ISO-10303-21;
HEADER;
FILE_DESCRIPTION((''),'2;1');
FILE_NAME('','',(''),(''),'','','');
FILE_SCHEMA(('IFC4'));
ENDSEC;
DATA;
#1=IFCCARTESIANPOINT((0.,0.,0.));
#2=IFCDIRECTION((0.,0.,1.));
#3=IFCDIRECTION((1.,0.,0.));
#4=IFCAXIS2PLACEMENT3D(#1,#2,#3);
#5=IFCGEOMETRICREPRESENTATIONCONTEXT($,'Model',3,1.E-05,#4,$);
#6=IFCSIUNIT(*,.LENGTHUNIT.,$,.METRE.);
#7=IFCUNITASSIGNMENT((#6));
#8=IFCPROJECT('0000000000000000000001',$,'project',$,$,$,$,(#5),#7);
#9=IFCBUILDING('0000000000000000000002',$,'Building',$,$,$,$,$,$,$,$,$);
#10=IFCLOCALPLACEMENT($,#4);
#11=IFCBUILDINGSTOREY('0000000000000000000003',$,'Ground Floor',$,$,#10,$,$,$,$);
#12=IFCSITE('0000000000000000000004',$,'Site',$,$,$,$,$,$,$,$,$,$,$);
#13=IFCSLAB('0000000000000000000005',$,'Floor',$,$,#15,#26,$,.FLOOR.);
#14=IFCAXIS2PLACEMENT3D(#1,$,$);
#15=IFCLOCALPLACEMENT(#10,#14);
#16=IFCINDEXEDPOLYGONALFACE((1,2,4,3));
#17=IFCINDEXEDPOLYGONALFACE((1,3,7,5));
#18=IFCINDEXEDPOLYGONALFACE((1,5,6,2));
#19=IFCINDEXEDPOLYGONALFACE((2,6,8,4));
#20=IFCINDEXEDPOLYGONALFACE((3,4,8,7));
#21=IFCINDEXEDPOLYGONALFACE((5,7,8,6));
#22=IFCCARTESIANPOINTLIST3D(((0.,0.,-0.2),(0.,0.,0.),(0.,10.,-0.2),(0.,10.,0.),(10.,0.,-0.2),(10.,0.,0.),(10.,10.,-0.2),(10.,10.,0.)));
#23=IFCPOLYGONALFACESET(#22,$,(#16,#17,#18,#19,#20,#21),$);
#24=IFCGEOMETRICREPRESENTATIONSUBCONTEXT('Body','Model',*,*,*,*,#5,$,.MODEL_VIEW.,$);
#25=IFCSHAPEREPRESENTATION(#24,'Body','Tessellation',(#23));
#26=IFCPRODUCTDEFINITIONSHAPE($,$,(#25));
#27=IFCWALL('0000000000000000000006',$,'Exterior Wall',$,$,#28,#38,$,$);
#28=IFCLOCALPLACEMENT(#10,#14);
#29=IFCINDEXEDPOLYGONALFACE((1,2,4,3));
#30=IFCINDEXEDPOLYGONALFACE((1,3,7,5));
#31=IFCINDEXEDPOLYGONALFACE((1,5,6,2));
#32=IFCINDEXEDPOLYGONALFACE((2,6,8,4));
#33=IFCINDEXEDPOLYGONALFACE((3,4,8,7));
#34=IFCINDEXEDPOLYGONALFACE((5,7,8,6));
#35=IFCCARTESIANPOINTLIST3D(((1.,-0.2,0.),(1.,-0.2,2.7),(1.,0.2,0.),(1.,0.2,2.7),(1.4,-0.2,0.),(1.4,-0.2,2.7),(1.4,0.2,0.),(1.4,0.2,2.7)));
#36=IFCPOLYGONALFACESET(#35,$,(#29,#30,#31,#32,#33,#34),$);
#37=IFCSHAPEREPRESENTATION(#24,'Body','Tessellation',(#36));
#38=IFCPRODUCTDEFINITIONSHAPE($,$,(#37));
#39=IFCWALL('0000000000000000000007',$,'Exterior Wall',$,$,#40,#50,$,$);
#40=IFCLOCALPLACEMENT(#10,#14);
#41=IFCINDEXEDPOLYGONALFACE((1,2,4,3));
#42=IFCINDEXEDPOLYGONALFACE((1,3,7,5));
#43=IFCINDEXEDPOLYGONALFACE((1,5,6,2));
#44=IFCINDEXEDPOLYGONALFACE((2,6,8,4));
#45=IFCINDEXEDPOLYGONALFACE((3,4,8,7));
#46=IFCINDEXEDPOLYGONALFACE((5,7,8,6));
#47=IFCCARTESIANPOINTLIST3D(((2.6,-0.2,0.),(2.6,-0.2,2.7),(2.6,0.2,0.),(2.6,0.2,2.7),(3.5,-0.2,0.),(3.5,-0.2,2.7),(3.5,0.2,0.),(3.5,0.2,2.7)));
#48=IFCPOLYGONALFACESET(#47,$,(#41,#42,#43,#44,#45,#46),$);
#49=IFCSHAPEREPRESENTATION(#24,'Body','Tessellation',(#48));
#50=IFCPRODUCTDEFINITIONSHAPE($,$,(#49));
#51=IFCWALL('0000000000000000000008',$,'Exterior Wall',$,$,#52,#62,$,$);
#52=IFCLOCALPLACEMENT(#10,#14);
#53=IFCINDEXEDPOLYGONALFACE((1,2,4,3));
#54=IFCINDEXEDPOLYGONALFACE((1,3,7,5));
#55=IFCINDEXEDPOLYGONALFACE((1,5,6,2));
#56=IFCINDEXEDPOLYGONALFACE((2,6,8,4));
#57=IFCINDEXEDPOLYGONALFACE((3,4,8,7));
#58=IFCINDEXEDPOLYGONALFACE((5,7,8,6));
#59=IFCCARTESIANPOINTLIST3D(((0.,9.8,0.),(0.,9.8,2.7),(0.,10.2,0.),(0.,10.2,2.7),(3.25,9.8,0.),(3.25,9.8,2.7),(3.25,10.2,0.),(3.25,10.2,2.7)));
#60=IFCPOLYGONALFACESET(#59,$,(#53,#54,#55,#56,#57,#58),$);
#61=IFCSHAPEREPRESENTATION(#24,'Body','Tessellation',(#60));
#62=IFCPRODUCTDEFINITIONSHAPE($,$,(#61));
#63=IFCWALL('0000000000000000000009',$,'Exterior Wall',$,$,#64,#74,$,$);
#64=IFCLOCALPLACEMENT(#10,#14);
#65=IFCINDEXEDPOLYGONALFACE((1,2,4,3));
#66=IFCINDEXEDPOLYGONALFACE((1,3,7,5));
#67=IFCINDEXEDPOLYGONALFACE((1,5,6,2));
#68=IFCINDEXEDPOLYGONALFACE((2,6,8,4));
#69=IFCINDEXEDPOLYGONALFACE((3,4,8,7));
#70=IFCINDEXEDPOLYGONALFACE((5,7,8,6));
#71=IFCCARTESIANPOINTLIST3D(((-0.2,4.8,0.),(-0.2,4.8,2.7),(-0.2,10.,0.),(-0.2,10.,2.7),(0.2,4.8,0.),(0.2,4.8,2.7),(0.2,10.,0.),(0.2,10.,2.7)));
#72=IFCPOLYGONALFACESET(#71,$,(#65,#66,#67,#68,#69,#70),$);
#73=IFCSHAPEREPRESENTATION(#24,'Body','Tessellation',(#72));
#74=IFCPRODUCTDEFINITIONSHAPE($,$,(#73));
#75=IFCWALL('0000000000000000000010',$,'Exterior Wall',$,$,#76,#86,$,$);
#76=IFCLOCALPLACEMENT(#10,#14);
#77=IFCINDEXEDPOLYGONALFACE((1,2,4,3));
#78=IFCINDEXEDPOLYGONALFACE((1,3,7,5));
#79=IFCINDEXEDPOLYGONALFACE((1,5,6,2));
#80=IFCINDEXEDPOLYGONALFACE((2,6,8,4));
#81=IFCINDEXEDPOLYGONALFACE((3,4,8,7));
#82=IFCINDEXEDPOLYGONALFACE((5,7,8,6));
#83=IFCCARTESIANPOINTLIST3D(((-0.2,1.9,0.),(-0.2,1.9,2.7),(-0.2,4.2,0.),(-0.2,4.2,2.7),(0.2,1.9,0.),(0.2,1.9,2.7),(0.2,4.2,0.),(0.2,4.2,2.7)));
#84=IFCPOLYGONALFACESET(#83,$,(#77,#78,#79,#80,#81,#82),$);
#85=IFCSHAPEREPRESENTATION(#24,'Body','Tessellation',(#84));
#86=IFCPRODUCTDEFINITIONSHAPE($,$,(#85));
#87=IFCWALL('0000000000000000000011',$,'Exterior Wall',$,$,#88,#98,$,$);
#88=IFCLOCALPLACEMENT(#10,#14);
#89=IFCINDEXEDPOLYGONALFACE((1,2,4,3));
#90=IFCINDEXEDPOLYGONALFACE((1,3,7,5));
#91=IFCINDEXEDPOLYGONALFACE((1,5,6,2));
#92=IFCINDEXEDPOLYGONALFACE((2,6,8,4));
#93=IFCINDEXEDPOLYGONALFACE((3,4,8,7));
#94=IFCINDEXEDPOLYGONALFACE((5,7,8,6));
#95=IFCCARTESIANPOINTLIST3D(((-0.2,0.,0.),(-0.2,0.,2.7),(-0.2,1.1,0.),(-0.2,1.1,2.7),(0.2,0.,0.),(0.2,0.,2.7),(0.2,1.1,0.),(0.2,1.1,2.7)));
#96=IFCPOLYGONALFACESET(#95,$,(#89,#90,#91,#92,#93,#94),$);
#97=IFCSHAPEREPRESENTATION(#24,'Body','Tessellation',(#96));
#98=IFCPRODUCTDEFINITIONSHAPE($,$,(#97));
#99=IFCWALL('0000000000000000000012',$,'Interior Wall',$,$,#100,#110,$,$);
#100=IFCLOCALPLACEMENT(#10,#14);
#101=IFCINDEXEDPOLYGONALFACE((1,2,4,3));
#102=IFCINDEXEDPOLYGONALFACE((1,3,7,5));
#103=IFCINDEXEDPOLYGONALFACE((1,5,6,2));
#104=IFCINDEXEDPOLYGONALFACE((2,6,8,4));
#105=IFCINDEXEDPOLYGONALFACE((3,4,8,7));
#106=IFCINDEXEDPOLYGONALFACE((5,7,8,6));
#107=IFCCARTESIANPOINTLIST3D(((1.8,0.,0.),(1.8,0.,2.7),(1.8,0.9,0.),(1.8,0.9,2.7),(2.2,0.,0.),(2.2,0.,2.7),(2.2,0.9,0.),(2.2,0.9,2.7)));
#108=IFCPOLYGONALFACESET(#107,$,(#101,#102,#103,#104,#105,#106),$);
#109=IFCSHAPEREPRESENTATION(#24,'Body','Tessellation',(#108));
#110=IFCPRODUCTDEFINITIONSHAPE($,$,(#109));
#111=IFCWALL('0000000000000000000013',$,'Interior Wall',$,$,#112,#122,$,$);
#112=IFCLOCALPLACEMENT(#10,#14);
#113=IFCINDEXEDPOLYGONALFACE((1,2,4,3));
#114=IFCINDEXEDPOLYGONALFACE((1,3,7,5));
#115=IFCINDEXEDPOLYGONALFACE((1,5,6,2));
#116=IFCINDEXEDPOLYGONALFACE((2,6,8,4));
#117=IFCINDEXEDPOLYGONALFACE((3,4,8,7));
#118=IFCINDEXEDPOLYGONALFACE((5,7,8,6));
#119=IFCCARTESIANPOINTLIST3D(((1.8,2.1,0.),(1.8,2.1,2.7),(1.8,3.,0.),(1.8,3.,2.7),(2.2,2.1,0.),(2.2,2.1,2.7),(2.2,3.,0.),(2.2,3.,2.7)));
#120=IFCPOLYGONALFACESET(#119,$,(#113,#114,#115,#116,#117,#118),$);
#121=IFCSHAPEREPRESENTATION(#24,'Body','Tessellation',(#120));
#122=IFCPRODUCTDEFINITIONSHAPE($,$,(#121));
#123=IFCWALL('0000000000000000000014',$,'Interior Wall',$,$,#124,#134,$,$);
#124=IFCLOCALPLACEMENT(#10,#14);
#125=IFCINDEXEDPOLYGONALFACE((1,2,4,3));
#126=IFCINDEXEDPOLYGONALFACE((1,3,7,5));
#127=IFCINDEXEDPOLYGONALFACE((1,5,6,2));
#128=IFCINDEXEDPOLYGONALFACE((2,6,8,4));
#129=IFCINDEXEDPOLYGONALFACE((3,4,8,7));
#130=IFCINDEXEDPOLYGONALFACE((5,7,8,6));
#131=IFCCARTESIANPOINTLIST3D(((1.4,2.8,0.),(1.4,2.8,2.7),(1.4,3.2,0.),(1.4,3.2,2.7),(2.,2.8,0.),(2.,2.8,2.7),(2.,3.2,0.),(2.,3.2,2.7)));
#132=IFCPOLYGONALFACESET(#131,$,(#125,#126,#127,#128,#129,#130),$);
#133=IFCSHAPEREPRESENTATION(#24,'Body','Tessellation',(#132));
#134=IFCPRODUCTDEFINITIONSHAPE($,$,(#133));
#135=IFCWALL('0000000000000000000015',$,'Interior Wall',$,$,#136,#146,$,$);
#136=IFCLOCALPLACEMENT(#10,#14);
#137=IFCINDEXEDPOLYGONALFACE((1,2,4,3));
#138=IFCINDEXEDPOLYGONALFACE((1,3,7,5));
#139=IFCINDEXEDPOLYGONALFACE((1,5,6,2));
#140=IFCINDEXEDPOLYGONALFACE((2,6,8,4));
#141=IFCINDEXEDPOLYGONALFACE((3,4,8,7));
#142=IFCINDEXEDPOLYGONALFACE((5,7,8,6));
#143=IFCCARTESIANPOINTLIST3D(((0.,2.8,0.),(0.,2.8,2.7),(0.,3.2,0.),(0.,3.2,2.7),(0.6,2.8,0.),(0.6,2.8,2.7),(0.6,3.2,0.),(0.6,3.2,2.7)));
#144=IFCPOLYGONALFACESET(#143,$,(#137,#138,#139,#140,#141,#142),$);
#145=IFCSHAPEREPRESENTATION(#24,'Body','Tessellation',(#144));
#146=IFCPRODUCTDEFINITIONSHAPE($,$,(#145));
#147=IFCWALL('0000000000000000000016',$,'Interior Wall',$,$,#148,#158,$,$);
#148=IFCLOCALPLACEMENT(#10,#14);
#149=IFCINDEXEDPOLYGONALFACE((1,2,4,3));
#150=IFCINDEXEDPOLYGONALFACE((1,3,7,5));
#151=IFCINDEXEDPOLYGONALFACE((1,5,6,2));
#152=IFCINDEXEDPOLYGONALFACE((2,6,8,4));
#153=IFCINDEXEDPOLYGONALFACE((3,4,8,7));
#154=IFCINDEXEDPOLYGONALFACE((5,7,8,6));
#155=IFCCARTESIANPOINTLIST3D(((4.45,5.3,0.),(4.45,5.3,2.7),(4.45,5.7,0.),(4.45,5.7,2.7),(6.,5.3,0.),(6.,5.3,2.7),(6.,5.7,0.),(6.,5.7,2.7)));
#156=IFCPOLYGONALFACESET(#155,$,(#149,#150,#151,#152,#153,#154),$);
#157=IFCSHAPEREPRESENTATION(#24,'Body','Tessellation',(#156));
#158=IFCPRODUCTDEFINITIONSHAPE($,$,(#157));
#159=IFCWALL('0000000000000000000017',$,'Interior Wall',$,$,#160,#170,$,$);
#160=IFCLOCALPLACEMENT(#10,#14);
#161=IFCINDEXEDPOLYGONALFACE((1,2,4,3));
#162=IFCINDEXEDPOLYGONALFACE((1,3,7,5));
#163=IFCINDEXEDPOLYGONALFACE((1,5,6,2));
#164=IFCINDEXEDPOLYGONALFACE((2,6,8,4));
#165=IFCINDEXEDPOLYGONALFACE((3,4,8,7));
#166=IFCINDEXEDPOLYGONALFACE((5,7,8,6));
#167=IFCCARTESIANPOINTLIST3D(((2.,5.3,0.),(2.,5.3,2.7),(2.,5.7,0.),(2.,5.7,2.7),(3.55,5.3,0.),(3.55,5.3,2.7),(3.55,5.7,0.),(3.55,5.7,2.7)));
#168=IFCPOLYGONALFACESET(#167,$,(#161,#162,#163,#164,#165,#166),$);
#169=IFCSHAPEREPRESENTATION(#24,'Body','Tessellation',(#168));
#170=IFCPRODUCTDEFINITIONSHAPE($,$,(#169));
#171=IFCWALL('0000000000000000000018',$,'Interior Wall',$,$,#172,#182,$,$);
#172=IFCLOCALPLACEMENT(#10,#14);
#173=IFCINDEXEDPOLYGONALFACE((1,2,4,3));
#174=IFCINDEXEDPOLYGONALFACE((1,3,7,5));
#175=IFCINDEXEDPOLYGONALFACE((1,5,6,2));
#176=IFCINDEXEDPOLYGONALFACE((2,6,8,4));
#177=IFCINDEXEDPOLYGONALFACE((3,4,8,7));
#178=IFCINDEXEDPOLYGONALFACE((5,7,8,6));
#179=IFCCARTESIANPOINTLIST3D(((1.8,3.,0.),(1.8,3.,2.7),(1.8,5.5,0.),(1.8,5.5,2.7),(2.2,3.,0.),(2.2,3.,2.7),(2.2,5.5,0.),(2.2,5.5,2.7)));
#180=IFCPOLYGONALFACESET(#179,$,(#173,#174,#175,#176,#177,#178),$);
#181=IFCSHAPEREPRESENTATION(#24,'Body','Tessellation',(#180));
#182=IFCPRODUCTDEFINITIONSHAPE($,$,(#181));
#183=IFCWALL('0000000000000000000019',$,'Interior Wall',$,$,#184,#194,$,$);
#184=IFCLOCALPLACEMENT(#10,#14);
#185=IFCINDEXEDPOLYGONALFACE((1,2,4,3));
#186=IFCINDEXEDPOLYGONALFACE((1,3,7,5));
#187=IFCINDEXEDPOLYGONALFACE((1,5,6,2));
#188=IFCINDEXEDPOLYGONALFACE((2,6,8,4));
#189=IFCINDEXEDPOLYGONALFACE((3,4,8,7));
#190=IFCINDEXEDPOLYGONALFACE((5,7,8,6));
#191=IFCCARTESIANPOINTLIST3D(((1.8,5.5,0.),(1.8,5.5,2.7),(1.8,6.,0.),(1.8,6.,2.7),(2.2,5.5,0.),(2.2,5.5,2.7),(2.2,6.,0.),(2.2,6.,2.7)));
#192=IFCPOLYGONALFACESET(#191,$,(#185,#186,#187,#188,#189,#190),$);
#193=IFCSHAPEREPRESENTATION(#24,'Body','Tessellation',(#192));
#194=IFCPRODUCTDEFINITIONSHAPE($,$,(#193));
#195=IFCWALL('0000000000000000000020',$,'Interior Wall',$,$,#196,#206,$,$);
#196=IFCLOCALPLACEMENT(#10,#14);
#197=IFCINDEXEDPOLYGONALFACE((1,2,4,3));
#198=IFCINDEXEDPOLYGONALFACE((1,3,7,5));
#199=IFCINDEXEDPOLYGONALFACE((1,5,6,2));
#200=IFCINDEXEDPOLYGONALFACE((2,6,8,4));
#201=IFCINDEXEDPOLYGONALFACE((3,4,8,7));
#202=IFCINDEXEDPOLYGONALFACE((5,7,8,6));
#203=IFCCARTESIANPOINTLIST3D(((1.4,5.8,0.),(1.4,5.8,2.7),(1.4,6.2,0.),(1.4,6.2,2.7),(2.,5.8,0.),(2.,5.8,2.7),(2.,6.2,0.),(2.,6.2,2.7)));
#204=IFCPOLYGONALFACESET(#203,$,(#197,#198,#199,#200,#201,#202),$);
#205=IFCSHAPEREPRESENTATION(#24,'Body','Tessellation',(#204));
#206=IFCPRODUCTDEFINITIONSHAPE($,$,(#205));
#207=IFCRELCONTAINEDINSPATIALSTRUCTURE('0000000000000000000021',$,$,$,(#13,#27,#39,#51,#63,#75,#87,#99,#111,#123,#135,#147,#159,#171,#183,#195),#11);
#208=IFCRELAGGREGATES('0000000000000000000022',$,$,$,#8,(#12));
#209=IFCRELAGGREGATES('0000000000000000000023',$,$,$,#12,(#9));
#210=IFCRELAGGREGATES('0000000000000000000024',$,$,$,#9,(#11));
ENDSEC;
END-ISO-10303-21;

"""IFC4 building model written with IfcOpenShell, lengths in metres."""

from ifc_helpers import new_model, si_unit, frame, origin_with_axes, place, context, subcontext, project, spatial, indexed_curve, outline, extrude, element, save


model = new_model("IFC4")

# Units and contexts
model_context = context("Model", 3, precision=1e-05, world=origin_with_axes())
body_context = subcontext(model_context, "Body", "Model", "MODEL_VIEW")
ifc_project = project(units=[si_unit("LENGTHUNIT", "METRE")], contexts=[model_context])

# Site, building, storey
site = spatial("IfcSite", under=ifc_project, Name="Site")
building = spatial("IfcBuilding", under=site, Name="Building")
storey_placement = place(None, origin_with_axes())
storey = spatial("IfcBuildingStorey", under=building, at=storey_placement, Name="Ground Floor")

# Slab
slab_placement = place(storey_placement, frame((0.0, 0.0, -0.2), z_axis=(0.0, 0.0, 1.0), x_axis=(1.0, 0.0, 0.0)))
element("IfcSlab", 1, at=slab_placement, inside=storey, Name="Floor", PredefinedType="FLOOR", context=body_context, shape_type="SweptSolid", body=[
    extrude(outline(indexed_curve([(0.0, 0.0), (10.0, 0.0), (10.0, 10.0), (0.0, 10.0)])), None, (0.0, 0.0, 1.0), 0.2),
])

# Walls
wall_1_placement = place(storey_placement, frame((1.0, 0.0, 0.0), z_axis=(0.0, 0.0, 1.0), x_axis=(1.0, 0.0, 0.0)))
element("IfcWall", 2, at=wall_1_placement, inside=storey, Name="Exterior Wall", context=body_context, shape_type="SweptSolid", body=[
    extrude(outline(indexed_curve([(0.0, 0.0), (0.0, 0.4), (0.4, 0.4), (0.4, 0.0), (0.0, 0.0)], self_intersect=False)), frame((0.0, -0.2, 0.0), z_axis=(0.0, 0.0, 1.0), x_axis=(1.0, 0.0, 0.0)), (0.0, 0.0, 1.0), 2.7),
])
wall_2_placement = place(storey_placement, frame((2.6, 0.0, 0.0), z_axis=(0.0, 0.0, 1.0), x_axis=(1.0, 0.0, 0.0)))
element("IfcWall", 3, at=wall_2_placement, inside=storey, Name="Exterior Wall", context=body_context, shape_type="SweptSolid", body=[
    extrude(outline(indexed_curve([(0.0, 0.0), (0.0, 0.4), (0.9, 0.4), (0.9, 0.0), (0.0, 0.0)], self_intersect=False)), frame((0.0, -0.2, 0.0), z_axis=(0.0, 0.0, 1.0), x_axis=(1.0, 0.0, 0.0)), (0.0, 0.0, 1.0), 2.7),
])
wall_3_placement = place(storey_placement, frame((3.25, 10.0, 0.0), z_axis=(0.0, 0.0, 1.0), x_axis=(-1.0, 0.0, 0.0)))
element("IfcWall", 4, at=wall_3_placement, inside=storey, Name="Exterior Wall", context=body_context, shape_type="SweptSolid", body=[
    extrude(outline(indexed_curve([(0.0, 0.0), (0.0, 0.4), (3.25, 0.4), (3.25, 0.0), (0.0, 0.0)], self_intersect=False)), frame((0.0, -0.2, 0.0), z_axis=(0.0, 0.0, 1.0), x_axis=(1.0, 0.0, 0.0)), (0.0, 0.0, 1.0), 2.7),
])
wall_4_placement = place(storey_placement, frame((0.0, 10.0, 0.0), z_axis=(0.0, 0.0, 1.0), x_axis=(0.0, -1.0, 0.0)))
element("IfcWall", 5, at=wall_4_placement, inside=storey, Name="Exterior Wall", context=body_context, shape_type="SweptSolid", body=[
    extrude(outline(indexed_curve([(0.0, 0.0), (0.0, 0.4), (5.2, 0.4), (5.2, 0.0), (0.0, 0.0)], self_intersect=False)), frame((0.0, -0.2, 0.0), z_axis=(0.0, 0.0, 1.0), x_axis=(1.0, 0.0, 0.0)), (0.0, 0.0, 1.0), 2.7),
])
wall_5_placement = place(storey_placement, frame((0.0, 4.2, 0.0), z_axis=(0.0, 0.0, 1.0), x_axis=(0.0, -1.0, 0.0)))
element("IfcWall", 6, at=wall_5_placement, inside=storey, Name="Exterior Wall", context=body_context, shape_type="SweptSolid", body=[
    extrude(outline(indexed_curve([(0.0, 0.0), (0.0, 0.4), (2.3, 0.4), (2.3, 0.0), (0.0, 0.0)], self_intersect=False)), frame((0.0, -0.2, 0.0), z_axis=(0.0, 0.0, 1.0), x_axis=(1.0, 0.0, 0.0)), (0.0, 0.0, 1.0), 2.7),
])
wall_6_placement = place(storey_placement, frame((0.0, 1.1, 0.0), z_axis=(0.0, 0.0, 1.0), x_axis=(0.0, -1.0, 0.0)))
element("IfcWall", 7, at=wall_6_placement, inside=storey, Name="Exterior Wall", context=body_context, shape_type="SweptSolid", body=[
    extrude(outline(indexed_curve([(0.0, 0.0), (0.0, 0.4), (1.1, 0.4), (1.1, 0.0), (0.0, 0.0)], self_intersect=False)), frame((0.0, -0.2, 0.0), z_axis=(0.0, 0.0, 1.0), x_axis=(1.0, 0.0, 0.0)), (0.0, 0.0, 1.0), 2.7),
])
wall_7_placement = place(storey_placement, frame((2.0, 0.0, 0.0), z_axis=(0.0, 0.0, 1.0), x_axis=(0.0, 1.0, 0.0)))
element("IfcWall", 8, at=wall_7_placement, inside=storey, Name="Interior Wall", context=body_context, shape_type="SweptSolid", body=[
    extrude(outline(indexed_curve([(0.0, 0.0), (0.0, 0.4), (0.9, 0.4), (0.9, 0.0), (0.0, 0.0)], self_intersect=False)), frame((0.0, -0.2, 0.0), z_axis=(0.0, 0.0, 1.0), x_axis=(1.0, 0.0, 0.0)), (0.0, 0.0, 1.0), 2.7),
])
wall_8_placement = place(storey_placement, frame((2.0, 2.1, 0.0), z_axis=(0.0, 0.0, 1.0), x_axis=(0.0, 1.0, 0.0)))
element("IfcWall", 9, at=wall_8_placement, inside=storey, Name="Interior Wall", context=body_context, shape_type="SweptSolid", body=[
    extrude(outline(indexed_curve([(0.0, 0.0), (0.0, 0.4), (0.9, 0.4), (0.9, 0.0), (0.0, 0.0)], self_intersect=False)), frame((0.0, -0.2, 0.0), z_axis=(0.0, 0.0, 1.0), x_axis=(1.0, 0.0, 0.0)), (0.0, 0.0, 1.0), 2.7),
])
for number, where, z_axis, x_axis, name in (
    (10, (2.0, 3.0, 0.0), (0.0, 0.0, 1.0), (-1.0, 0.0, 0.0), "Interior Wall"),
    (11, (0.6, 3.0, 0.0), (0.0, 0.0, 1.0), (-1.0, 0.0, 0.0), "Interior Wall"),
):
    element("IfcWall", number, at=place(storey_placement, frame(where, z_axis=z_axis, x_axis=x_axis)), inside=storey, Name=name, context=body_context, shape_type="SweptSolid", body=[
        extrude(outline(indexed_curve([(0.0, 0.0), (0.0, 0.4), (0.6, 0.4), (0.6, 0.0), (0.0, 0.0)], self_intersect=False)), frame((0.0, -0.2, 0.0), z_axis=(0.0, 0.0, 1.0), x_axis=(1.0, 0.0, 0.0)), (0.0, 0.0, 1.0), 2.7),
    ])
for number, where, z_axis, x_axis, name in (
    (12, (6.0, 5.5, 0.0), (0.0, 0.0, 1.0), (-1.0, 0.0, 0.0), "Interior Wall"),
    (13, (3.55, 5.5, 0.0), (0.0, 0.0, 1.0), (-1.0, 0.0, 0.0), "Interior Wall"),
):
    element("IfcWall", number, at=place(storey_placement, frame(where, z_axis=z_axis, x_axis=x_axis)), inside=storey, Name=name, context=body_context, shape_type="SweptSolid", body=[
        extrude(outline(indexed_curve([(0.0, 0.0), (0.0, 0.4), (1.55, 0.4), (1.55, 0.0), (0.0, 0.0)], self_intersect=False)), frame((0.0, -0.2, 0.0), z_axis=(0.0, 0.0, 1.0), x_axis=(1.0, 0.0, 0.0)), (0.0, 0.0, 1.0), 2.7),
    ])
wall_9_placement = place(storey_placement, frame((2.0, 5.5, 0.0), z_axis=(0.0, 0.0, 1.0), x_axis=(0.0, -1.0, 0.0)))
element("IfcWall", 14, at=wall_9_placement, inside=storey, Name="Interior Wall", context=body_context, shape_type="SweptSolid", body=[
    extrude(outline(indexed_curve([(0.0, 0.0), (0.0, 0.4), (2.5, 0.4), (2.5, 0.0), (0.0, 0.0)], self_intersect=False)), frame((0.0, -0.2, 0.0), z_axis=(0.0, 0.0, 1.0), x_axis=(1.0, 0.0, 0.0)), (0.0, 0.0, 1.0), 2.7),
])
wall_10_placement = place(storey_placement, frame((2.0, 5.5, 0.0), z_axis=(0.0, 0.0, 1.0), x_axis=(0.0, 1.0, 0.0)))
element("IfcWall", 15, at=wall_10_placement, inside=storey, Name="Interior Wall", context=body_context, shape_type="SweptSolid", body=[
    extrude(outline(indexed_curve([(0.0, 0.0), (0.0, 0.4), (0.5, 0.4), (0.5, 0.0), (0.0, 0.0)], self_intersect=False)), frame((0.0, -0.2, 0.0), z_axis=(0.0, 0.0, 1.0), x_axis=(1.0, 0.0, 0.0)), (0.0, 0.0, 1.0), 2.7),
])
for number, where, z_axis, x_axis, name in (
    (16, (2.0, 6.0, 0.0), (0.0, 0.0, 1.0), (-1.0, 0.0, 0.0), "Interior Wall"),
):
    element("IfcWall", number, at=place(storey_placement, frame(where, z_axis=z_axis, x_axis=x_axis)), inside=storey, Name=name, context=body_context, shape_type="SweptSolid", body=[
        extrude(outline(indexed_curve([(0.0, 0.0), (0.0, 0.4), (0.6, 0.4), (0.6, 0.0), (0.0, 0.0)], self_intersect=False)), frame((0.0, -0.2, 0.0), z_axis=(0.0, 0.0, 1.0), x_axis=(1.0, 0.0, 0.0)), (0.0, 0.0, 1.0), 2.7),
    ])

save(model, "model.ifc")
